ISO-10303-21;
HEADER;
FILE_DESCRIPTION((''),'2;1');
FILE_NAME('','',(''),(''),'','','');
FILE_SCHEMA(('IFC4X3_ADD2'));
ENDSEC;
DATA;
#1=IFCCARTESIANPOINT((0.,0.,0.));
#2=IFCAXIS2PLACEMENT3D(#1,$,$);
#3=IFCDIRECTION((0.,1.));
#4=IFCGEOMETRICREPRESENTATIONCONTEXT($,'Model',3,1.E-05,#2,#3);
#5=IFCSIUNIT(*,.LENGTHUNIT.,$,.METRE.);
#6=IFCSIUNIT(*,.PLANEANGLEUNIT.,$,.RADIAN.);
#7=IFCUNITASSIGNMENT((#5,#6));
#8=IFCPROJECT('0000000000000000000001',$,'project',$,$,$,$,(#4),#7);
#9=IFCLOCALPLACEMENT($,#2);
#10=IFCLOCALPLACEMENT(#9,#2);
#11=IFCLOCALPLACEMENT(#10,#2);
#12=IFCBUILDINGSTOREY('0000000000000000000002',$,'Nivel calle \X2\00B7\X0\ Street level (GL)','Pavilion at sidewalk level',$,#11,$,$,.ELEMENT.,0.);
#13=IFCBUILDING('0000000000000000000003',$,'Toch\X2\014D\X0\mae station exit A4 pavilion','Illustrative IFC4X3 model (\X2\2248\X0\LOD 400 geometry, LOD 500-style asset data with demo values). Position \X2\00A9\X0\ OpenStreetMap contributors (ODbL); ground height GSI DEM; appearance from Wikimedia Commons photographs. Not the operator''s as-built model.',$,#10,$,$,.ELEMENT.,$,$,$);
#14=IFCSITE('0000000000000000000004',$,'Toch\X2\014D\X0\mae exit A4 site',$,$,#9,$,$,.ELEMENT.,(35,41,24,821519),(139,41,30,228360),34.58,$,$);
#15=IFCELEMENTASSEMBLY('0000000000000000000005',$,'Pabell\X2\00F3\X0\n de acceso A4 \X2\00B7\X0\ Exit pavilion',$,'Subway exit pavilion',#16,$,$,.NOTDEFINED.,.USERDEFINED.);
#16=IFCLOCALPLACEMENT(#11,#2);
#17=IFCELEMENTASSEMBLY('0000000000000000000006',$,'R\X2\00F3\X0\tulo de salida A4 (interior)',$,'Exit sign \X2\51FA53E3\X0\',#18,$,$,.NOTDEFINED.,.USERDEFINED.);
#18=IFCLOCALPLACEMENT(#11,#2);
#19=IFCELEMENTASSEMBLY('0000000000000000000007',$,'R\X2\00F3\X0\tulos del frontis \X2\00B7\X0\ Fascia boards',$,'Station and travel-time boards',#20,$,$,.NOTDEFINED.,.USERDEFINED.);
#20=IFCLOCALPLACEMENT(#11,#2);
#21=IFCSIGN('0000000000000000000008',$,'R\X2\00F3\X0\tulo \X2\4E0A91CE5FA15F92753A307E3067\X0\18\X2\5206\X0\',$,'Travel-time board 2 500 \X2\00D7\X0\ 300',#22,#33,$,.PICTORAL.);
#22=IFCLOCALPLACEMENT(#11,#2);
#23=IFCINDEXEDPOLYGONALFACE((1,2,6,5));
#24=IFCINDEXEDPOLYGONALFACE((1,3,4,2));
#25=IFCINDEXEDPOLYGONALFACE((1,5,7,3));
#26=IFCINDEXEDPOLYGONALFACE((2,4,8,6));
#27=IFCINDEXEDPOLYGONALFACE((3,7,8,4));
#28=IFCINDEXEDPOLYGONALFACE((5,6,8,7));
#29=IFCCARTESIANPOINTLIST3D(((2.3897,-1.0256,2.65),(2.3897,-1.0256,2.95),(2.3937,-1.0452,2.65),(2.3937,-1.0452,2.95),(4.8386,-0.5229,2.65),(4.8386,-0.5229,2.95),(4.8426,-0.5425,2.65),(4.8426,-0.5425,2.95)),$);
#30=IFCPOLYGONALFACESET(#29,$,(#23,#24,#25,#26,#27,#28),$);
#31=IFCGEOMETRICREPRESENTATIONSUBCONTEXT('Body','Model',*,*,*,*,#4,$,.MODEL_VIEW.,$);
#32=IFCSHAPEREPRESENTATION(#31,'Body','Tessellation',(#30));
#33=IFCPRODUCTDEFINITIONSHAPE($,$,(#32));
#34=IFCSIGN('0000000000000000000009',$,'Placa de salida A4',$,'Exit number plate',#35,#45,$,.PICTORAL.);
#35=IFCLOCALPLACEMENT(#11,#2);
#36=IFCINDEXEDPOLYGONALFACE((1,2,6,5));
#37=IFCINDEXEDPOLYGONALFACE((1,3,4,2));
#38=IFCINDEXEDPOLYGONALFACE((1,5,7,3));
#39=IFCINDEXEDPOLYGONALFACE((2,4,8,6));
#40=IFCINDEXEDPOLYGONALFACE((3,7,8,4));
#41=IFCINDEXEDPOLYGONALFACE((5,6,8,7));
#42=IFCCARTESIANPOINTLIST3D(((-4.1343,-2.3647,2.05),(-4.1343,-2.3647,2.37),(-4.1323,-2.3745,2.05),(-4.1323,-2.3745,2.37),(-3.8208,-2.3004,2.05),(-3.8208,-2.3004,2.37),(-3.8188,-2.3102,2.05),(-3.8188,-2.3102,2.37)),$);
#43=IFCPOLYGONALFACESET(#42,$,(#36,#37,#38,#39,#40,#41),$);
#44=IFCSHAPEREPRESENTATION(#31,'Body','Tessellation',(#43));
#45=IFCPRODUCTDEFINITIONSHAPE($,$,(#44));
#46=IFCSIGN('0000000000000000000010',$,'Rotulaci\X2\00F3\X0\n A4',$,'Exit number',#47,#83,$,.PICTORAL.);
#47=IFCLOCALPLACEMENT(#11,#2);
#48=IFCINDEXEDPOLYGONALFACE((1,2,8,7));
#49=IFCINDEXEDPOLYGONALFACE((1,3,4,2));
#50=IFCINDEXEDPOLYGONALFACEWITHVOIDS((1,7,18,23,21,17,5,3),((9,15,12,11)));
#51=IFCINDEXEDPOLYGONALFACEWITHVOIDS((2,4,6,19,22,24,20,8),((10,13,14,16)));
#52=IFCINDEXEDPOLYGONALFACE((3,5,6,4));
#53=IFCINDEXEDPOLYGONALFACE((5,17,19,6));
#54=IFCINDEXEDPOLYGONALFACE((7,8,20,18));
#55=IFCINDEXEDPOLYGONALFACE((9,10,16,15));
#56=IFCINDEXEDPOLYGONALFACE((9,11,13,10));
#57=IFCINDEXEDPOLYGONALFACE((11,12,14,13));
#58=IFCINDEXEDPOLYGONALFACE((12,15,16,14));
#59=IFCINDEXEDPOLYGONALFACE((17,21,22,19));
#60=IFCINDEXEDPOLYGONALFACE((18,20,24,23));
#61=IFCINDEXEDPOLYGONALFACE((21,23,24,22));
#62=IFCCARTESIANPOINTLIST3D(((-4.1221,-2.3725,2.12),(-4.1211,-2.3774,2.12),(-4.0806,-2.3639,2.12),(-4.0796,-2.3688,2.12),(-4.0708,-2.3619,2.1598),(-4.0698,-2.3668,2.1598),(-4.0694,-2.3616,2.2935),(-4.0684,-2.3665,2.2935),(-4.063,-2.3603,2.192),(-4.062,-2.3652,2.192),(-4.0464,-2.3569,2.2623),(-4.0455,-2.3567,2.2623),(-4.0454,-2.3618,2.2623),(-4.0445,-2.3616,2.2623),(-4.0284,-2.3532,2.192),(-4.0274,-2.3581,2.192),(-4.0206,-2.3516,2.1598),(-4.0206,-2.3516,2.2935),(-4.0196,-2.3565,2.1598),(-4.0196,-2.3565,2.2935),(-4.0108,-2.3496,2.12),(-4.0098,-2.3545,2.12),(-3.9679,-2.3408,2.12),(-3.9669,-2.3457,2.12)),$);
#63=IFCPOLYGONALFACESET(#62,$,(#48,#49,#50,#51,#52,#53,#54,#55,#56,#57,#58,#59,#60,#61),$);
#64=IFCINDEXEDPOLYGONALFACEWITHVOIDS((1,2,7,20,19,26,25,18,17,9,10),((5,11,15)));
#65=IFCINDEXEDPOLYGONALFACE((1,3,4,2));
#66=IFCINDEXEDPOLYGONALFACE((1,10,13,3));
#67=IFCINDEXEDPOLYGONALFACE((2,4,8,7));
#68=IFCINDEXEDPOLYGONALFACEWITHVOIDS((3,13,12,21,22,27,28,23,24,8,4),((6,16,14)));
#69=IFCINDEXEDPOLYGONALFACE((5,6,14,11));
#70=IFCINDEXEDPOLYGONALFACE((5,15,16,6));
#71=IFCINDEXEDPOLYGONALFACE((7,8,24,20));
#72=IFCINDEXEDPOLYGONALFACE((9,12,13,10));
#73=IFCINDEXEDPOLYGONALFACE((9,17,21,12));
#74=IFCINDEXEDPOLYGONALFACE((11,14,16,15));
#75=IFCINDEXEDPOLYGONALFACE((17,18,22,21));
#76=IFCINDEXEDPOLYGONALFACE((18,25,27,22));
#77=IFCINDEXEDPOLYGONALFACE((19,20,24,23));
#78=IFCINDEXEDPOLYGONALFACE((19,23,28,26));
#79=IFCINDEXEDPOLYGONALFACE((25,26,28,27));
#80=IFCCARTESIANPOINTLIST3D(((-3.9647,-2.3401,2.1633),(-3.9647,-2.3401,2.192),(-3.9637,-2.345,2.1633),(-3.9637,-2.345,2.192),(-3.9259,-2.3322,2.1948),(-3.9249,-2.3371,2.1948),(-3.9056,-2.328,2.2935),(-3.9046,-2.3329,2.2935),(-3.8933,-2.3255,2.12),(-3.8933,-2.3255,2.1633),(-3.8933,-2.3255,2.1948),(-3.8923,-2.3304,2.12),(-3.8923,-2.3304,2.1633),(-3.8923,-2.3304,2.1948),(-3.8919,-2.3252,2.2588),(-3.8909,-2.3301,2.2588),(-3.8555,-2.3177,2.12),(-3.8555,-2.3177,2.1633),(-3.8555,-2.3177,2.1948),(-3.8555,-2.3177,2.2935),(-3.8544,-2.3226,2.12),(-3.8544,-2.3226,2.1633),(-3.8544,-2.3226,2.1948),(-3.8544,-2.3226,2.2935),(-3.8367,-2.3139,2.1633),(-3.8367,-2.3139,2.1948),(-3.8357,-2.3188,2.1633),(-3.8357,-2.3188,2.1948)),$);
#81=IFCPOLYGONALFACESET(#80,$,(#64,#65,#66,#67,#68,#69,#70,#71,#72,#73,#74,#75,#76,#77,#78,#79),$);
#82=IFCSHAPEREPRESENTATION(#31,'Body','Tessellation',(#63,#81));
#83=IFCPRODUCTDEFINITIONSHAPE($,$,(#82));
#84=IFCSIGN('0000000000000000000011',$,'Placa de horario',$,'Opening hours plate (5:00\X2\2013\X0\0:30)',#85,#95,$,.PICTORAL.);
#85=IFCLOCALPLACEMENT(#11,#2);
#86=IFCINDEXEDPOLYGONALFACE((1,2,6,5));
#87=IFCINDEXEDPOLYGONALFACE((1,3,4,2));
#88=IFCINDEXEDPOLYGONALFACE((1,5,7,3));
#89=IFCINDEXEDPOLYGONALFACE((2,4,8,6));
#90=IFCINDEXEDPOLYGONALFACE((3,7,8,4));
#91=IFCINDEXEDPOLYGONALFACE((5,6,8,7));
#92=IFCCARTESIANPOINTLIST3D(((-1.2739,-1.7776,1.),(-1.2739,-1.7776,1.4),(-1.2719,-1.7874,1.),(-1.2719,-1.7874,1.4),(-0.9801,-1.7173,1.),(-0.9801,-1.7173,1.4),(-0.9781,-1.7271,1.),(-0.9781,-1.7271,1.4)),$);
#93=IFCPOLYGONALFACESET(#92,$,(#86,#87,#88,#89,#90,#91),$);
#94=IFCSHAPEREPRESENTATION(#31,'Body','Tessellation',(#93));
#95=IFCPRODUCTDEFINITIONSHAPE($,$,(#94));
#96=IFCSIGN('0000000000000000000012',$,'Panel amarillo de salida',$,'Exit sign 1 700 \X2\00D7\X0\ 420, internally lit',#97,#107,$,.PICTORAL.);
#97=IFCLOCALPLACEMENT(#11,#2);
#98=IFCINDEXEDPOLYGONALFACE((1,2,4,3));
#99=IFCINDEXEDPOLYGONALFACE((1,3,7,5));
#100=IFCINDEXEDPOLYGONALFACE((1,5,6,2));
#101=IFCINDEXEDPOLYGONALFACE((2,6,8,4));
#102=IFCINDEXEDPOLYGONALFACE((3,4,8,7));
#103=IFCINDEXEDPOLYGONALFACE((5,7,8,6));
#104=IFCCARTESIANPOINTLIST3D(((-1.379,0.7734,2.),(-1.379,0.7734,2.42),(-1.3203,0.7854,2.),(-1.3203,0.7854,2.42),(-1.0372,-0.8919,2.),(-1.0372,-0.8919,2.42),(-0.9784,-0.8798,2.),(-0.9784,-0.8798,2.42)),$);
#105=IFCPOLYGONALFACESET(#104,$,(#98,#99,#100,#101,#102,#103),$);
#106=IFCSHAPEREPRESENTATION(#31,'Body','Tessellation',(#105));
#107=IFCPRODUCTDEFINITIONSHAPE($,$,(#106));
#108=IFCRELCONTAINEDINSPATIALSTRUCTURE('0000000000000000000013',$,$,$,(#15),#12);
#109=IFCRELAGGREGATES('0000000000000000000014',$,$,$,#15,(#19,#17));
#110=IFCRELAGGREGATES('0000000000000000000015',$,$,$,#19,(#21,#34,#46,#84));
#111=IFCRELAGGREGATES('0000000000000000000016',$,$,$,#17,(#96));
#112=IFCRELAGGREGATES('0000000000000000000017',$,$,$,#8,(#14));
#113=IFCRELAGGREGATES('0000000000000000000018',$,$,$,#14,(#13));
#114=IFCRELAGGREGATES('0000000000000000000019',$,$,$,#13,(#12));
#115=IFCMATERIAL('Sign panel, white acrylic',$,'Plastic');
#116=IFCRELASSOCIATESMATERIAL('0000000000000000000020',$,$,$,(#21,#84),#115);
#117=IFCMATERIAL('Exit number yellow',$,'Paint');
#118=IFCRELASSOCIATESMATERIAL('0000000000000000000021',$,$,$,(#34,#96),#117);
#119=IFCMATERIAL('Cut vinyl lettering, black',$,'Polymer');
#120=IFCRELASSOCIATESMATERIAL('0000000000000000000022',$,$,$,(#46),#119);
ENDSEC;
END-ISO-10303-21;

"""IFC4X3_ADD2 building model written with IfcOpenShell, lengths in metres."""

from ifc_helpers import new_model, si_unit, direction, frame, frame_2d, origin, place, context, subcontext, project, spatial, polyline, rectangle, outline, extrude, material, element, aggregate, save


model = new_model("IFC4X3_ADD2")

# Units and contexts
model_context = context("Model", 3, precision=1e-05, world=origin(), true_north=direction((0.0, 1.0)))
body_context = subcontext(model_context, "Body", "Model", "MODEL_VIEW")
ifc_project = project(units=[si_unit("LENGTHUNIT", "METRE"), si_unit("PLANEANGLEUNIT", "RADIAN")], contexts=[model_context])

# Site, building, storey
site_placement = place(None, origin())
site = spatial("IfcSite", under=ifc_project, at=site_placement, Name="Tochōmae exit A4 site", CompositionType="ELEMENT", RefLatitude=(35, 41, 24, 821519), RefLongitude=(139, 41, 30, 228360), RefElevation=34.58)
building_placement = place(site_placement, origin())
building = spatial("IfcBuilding", under=site, at=building_placement, Name="Tochōmae station exit A4 pavilion", Description="Illustrative IFC4X3 model (≈LOD 400 geometry, LOD 500-style asset data with demo values). Position © OpenStreetMap contributors (ODbL); ground height GSI DEM; appearance from Wikimedia Commons photographs. Not the operator's as-built model.", CompositionType="ELEMENT")
storey_placement = place(building_placement, origin())
storey = spatial("IfcBuildingStorey", under=building, at=storey_placement, Name="Nivel calle · Street level (GL)", Description="Pavilion at sidewalk level", CompositionType="ELEMENT", Elevation=0.0)

# Element assemblies, signs
assembly_1_placement = place(building_placement, origin())
assembly_1 = element("IfcElementAssembly", 1, at=assembly_1_placement, inside=storey, Name="Pabellón de acceso A4 · Exit pavilion", ObjectType="Subway exit pavilion", AssemblyPlace="NOTDEFINED", PredefinedType="USERDEFINED")
assembly_2_placement = place(building_placement, origin())
assembly_2 = element("IfcElementAssembly", 2, at=assembly_2_placement, Name="Rótulo de salida A4 (interior)", ObjectType="Exit sign 出口", AssemblyPlace="NOTDEFINED", PredefinedType="USERDEFINED")
assembly_3_placement = place(building_placement, origin())
assembly_3 = element("IfcElementAssembly", 3, at=assembly_3_placement, Name="Rótulos del frontis · Fascia boards", ObjectType="Station and travel-time boards", AssemblyPlace="NOTDEFINED", PredefinedType="USERDEFINED")
aggregate(assembly_1, [assembly_3, assembly_2])
ifc_material_1 = material(Name="Sign panel, white acrylic", Category="Plastic")
ifc_material_2 = material(Name="Cut vinyl lettering, black", Category="Polymer")
sign_1_placement = place(building_placement, origin())
sign_1 = element("IfcSign", 4, at=sign_1_placement, material=ifc_material_1, Name="Rótulo 上野御徒町まで18分", ObjectType="Travel-time board 2 500 × 300", PredefinedType="PICTORAL", context=body_context, shape_type="SweptSolid", body=[
    extrude(outline(polyline([(-1.25, 2.65), (1.25, 2.65), (1.25, 2.95), (-1.25, 2.95), (-1.25, 2.65)])), frame((3.6141, -0.7742, 0.0), z_axis=(0.201078, -0.979575, 0.0), x_axis=(0.979575, 0.201078, 0.0)), (0.0, 0.0, 1.0), 0.02),
])
ifc_material_3 = material(Name="Exit number yellow", Category="Paint")
sign_2_placement = place(building_placement, origin())
sign_2 = element("IfcSign", 5, at=sign_2_placement, material=ifc_material_3, Name="Placa de salida A4", ObjectType="Exit number plate", PredefinedType="PICTORAL", context=body_context, shape_type="SweptSolid", body=[
    extrude(outline(polyline([(-0.16, 2.05), (0.16, 2.05), (0.16, 2.37), (-0.16, 2.37), (-0.16, 2.05)])), frame((-3.9776, -2.3326, 0.0), z_axis=(0.201078, -0.979575, 0.0), x_axis=(0.979575, 0.201078, 0.0)), (0.0, 0.0, 1.0), 0.01),
])
sign_3_placement = place(building_placement, origin())
sign_3 = element("IfcSign", 6, at=sign_3_placement, material=ifc_material_2, Name="Rotulación A4", ObjectType="Exit number", PredefinedType="PICTORAL", context=body_context, shape_type="SweptSolid", body=[
    extrude(outline(polyline([(0.0519, 0.1735), (0.1018, 0.1735), (0.1556, 0.0), (0.1118, 0.0), (0.1018, 0.0398), (0.0505, 0.0398), (0.0405, 0.0), (-0.0019, 0.0), (0.0519, 0.1735)]), holes=[polyline([(0.0938, 0.072), (0.0764, 0.1423), (0.0755, 0.1423), (0.0585, 0.072), (0.0938, 0.072)])]), frame((-4.1203, -2.3721, 2.12), z_axis=(0.201078, -0.979575, 0.0), x_axis=(0.979575, 0.201078, 0.0)), (0.0, 0.0, 1.0), 0.005),
    extrude(outline(polyline([(0.2317, 0.0433), (0.1588, 0.0433), (0.1588, 0.072), (0.2191, 0.1735), (0.2704, 0.1735), (0.2704, 0.0748), (0.2895, 0.0748), (0.2895, 0.0433), (0.2704, 0.0433), (0.2704, 0.0), (0.2317, 0.0), (0.2317, 0.0433)]), holes=[polyline([(0.2317, 0.0748), (0.2331, 0.1388), (0.1984, 0.0748), (0.2317, 0.0748)])]), frame((-4.1203, -2.3721, 2.12), z_axis=(0.201078, -0.979575, 0.0), x_axis=(0.979575, 0.201078, 0.0)), (0.0, 0.0, 1.0), 0.005),
])
sign_4_placement = place(building_placement, origin())
sign_4 = element("IfcSign", 7, at=sign_4_placement, material=ifc_material_1, Name="Placa de horario", ObjectType="Opening hours plate (5:00–0:30)", PredefinedType="PICTORAL", context=body_context, shape_type="SweptSolid", body=[
    extrude(rectangle(XDim=0.3, YDim=0.01, at=frame_2d((0.0, 0.0), x_axis=(0.979575, 0.201078))), frame((-1.126, -1.7523, 1.0)), (0.0, 0.0, 1.0), 0.4),
])
aggregate(assembly_3, [sign_1, sign_2, sign_3, sign_4])
sign_5_placement = place(building_placement, origin())
sign_5 = element("IfcSign", 8, at=sign_5_placement, material=ifc_material_3, Name="Panel amarillo de salida", ObjectType="Exit sign 1 700 × 420, internally lit", PredefinedType="PICTORAL", context=body_context, shape_type="SweptSolid", body=[
    extrude(rectangle(XDim=0.06, YDim=1.7, at=frame_2d((0.0, 0.0), x_axis=(0.979575, 0.201078))), frame((-1.1787, -0.0532, 2.0)), (0.0, 0.0, 1.0), 0.42),
])
aggregate(assembly_2, [sign_5])

save(model, "model.ifc")
